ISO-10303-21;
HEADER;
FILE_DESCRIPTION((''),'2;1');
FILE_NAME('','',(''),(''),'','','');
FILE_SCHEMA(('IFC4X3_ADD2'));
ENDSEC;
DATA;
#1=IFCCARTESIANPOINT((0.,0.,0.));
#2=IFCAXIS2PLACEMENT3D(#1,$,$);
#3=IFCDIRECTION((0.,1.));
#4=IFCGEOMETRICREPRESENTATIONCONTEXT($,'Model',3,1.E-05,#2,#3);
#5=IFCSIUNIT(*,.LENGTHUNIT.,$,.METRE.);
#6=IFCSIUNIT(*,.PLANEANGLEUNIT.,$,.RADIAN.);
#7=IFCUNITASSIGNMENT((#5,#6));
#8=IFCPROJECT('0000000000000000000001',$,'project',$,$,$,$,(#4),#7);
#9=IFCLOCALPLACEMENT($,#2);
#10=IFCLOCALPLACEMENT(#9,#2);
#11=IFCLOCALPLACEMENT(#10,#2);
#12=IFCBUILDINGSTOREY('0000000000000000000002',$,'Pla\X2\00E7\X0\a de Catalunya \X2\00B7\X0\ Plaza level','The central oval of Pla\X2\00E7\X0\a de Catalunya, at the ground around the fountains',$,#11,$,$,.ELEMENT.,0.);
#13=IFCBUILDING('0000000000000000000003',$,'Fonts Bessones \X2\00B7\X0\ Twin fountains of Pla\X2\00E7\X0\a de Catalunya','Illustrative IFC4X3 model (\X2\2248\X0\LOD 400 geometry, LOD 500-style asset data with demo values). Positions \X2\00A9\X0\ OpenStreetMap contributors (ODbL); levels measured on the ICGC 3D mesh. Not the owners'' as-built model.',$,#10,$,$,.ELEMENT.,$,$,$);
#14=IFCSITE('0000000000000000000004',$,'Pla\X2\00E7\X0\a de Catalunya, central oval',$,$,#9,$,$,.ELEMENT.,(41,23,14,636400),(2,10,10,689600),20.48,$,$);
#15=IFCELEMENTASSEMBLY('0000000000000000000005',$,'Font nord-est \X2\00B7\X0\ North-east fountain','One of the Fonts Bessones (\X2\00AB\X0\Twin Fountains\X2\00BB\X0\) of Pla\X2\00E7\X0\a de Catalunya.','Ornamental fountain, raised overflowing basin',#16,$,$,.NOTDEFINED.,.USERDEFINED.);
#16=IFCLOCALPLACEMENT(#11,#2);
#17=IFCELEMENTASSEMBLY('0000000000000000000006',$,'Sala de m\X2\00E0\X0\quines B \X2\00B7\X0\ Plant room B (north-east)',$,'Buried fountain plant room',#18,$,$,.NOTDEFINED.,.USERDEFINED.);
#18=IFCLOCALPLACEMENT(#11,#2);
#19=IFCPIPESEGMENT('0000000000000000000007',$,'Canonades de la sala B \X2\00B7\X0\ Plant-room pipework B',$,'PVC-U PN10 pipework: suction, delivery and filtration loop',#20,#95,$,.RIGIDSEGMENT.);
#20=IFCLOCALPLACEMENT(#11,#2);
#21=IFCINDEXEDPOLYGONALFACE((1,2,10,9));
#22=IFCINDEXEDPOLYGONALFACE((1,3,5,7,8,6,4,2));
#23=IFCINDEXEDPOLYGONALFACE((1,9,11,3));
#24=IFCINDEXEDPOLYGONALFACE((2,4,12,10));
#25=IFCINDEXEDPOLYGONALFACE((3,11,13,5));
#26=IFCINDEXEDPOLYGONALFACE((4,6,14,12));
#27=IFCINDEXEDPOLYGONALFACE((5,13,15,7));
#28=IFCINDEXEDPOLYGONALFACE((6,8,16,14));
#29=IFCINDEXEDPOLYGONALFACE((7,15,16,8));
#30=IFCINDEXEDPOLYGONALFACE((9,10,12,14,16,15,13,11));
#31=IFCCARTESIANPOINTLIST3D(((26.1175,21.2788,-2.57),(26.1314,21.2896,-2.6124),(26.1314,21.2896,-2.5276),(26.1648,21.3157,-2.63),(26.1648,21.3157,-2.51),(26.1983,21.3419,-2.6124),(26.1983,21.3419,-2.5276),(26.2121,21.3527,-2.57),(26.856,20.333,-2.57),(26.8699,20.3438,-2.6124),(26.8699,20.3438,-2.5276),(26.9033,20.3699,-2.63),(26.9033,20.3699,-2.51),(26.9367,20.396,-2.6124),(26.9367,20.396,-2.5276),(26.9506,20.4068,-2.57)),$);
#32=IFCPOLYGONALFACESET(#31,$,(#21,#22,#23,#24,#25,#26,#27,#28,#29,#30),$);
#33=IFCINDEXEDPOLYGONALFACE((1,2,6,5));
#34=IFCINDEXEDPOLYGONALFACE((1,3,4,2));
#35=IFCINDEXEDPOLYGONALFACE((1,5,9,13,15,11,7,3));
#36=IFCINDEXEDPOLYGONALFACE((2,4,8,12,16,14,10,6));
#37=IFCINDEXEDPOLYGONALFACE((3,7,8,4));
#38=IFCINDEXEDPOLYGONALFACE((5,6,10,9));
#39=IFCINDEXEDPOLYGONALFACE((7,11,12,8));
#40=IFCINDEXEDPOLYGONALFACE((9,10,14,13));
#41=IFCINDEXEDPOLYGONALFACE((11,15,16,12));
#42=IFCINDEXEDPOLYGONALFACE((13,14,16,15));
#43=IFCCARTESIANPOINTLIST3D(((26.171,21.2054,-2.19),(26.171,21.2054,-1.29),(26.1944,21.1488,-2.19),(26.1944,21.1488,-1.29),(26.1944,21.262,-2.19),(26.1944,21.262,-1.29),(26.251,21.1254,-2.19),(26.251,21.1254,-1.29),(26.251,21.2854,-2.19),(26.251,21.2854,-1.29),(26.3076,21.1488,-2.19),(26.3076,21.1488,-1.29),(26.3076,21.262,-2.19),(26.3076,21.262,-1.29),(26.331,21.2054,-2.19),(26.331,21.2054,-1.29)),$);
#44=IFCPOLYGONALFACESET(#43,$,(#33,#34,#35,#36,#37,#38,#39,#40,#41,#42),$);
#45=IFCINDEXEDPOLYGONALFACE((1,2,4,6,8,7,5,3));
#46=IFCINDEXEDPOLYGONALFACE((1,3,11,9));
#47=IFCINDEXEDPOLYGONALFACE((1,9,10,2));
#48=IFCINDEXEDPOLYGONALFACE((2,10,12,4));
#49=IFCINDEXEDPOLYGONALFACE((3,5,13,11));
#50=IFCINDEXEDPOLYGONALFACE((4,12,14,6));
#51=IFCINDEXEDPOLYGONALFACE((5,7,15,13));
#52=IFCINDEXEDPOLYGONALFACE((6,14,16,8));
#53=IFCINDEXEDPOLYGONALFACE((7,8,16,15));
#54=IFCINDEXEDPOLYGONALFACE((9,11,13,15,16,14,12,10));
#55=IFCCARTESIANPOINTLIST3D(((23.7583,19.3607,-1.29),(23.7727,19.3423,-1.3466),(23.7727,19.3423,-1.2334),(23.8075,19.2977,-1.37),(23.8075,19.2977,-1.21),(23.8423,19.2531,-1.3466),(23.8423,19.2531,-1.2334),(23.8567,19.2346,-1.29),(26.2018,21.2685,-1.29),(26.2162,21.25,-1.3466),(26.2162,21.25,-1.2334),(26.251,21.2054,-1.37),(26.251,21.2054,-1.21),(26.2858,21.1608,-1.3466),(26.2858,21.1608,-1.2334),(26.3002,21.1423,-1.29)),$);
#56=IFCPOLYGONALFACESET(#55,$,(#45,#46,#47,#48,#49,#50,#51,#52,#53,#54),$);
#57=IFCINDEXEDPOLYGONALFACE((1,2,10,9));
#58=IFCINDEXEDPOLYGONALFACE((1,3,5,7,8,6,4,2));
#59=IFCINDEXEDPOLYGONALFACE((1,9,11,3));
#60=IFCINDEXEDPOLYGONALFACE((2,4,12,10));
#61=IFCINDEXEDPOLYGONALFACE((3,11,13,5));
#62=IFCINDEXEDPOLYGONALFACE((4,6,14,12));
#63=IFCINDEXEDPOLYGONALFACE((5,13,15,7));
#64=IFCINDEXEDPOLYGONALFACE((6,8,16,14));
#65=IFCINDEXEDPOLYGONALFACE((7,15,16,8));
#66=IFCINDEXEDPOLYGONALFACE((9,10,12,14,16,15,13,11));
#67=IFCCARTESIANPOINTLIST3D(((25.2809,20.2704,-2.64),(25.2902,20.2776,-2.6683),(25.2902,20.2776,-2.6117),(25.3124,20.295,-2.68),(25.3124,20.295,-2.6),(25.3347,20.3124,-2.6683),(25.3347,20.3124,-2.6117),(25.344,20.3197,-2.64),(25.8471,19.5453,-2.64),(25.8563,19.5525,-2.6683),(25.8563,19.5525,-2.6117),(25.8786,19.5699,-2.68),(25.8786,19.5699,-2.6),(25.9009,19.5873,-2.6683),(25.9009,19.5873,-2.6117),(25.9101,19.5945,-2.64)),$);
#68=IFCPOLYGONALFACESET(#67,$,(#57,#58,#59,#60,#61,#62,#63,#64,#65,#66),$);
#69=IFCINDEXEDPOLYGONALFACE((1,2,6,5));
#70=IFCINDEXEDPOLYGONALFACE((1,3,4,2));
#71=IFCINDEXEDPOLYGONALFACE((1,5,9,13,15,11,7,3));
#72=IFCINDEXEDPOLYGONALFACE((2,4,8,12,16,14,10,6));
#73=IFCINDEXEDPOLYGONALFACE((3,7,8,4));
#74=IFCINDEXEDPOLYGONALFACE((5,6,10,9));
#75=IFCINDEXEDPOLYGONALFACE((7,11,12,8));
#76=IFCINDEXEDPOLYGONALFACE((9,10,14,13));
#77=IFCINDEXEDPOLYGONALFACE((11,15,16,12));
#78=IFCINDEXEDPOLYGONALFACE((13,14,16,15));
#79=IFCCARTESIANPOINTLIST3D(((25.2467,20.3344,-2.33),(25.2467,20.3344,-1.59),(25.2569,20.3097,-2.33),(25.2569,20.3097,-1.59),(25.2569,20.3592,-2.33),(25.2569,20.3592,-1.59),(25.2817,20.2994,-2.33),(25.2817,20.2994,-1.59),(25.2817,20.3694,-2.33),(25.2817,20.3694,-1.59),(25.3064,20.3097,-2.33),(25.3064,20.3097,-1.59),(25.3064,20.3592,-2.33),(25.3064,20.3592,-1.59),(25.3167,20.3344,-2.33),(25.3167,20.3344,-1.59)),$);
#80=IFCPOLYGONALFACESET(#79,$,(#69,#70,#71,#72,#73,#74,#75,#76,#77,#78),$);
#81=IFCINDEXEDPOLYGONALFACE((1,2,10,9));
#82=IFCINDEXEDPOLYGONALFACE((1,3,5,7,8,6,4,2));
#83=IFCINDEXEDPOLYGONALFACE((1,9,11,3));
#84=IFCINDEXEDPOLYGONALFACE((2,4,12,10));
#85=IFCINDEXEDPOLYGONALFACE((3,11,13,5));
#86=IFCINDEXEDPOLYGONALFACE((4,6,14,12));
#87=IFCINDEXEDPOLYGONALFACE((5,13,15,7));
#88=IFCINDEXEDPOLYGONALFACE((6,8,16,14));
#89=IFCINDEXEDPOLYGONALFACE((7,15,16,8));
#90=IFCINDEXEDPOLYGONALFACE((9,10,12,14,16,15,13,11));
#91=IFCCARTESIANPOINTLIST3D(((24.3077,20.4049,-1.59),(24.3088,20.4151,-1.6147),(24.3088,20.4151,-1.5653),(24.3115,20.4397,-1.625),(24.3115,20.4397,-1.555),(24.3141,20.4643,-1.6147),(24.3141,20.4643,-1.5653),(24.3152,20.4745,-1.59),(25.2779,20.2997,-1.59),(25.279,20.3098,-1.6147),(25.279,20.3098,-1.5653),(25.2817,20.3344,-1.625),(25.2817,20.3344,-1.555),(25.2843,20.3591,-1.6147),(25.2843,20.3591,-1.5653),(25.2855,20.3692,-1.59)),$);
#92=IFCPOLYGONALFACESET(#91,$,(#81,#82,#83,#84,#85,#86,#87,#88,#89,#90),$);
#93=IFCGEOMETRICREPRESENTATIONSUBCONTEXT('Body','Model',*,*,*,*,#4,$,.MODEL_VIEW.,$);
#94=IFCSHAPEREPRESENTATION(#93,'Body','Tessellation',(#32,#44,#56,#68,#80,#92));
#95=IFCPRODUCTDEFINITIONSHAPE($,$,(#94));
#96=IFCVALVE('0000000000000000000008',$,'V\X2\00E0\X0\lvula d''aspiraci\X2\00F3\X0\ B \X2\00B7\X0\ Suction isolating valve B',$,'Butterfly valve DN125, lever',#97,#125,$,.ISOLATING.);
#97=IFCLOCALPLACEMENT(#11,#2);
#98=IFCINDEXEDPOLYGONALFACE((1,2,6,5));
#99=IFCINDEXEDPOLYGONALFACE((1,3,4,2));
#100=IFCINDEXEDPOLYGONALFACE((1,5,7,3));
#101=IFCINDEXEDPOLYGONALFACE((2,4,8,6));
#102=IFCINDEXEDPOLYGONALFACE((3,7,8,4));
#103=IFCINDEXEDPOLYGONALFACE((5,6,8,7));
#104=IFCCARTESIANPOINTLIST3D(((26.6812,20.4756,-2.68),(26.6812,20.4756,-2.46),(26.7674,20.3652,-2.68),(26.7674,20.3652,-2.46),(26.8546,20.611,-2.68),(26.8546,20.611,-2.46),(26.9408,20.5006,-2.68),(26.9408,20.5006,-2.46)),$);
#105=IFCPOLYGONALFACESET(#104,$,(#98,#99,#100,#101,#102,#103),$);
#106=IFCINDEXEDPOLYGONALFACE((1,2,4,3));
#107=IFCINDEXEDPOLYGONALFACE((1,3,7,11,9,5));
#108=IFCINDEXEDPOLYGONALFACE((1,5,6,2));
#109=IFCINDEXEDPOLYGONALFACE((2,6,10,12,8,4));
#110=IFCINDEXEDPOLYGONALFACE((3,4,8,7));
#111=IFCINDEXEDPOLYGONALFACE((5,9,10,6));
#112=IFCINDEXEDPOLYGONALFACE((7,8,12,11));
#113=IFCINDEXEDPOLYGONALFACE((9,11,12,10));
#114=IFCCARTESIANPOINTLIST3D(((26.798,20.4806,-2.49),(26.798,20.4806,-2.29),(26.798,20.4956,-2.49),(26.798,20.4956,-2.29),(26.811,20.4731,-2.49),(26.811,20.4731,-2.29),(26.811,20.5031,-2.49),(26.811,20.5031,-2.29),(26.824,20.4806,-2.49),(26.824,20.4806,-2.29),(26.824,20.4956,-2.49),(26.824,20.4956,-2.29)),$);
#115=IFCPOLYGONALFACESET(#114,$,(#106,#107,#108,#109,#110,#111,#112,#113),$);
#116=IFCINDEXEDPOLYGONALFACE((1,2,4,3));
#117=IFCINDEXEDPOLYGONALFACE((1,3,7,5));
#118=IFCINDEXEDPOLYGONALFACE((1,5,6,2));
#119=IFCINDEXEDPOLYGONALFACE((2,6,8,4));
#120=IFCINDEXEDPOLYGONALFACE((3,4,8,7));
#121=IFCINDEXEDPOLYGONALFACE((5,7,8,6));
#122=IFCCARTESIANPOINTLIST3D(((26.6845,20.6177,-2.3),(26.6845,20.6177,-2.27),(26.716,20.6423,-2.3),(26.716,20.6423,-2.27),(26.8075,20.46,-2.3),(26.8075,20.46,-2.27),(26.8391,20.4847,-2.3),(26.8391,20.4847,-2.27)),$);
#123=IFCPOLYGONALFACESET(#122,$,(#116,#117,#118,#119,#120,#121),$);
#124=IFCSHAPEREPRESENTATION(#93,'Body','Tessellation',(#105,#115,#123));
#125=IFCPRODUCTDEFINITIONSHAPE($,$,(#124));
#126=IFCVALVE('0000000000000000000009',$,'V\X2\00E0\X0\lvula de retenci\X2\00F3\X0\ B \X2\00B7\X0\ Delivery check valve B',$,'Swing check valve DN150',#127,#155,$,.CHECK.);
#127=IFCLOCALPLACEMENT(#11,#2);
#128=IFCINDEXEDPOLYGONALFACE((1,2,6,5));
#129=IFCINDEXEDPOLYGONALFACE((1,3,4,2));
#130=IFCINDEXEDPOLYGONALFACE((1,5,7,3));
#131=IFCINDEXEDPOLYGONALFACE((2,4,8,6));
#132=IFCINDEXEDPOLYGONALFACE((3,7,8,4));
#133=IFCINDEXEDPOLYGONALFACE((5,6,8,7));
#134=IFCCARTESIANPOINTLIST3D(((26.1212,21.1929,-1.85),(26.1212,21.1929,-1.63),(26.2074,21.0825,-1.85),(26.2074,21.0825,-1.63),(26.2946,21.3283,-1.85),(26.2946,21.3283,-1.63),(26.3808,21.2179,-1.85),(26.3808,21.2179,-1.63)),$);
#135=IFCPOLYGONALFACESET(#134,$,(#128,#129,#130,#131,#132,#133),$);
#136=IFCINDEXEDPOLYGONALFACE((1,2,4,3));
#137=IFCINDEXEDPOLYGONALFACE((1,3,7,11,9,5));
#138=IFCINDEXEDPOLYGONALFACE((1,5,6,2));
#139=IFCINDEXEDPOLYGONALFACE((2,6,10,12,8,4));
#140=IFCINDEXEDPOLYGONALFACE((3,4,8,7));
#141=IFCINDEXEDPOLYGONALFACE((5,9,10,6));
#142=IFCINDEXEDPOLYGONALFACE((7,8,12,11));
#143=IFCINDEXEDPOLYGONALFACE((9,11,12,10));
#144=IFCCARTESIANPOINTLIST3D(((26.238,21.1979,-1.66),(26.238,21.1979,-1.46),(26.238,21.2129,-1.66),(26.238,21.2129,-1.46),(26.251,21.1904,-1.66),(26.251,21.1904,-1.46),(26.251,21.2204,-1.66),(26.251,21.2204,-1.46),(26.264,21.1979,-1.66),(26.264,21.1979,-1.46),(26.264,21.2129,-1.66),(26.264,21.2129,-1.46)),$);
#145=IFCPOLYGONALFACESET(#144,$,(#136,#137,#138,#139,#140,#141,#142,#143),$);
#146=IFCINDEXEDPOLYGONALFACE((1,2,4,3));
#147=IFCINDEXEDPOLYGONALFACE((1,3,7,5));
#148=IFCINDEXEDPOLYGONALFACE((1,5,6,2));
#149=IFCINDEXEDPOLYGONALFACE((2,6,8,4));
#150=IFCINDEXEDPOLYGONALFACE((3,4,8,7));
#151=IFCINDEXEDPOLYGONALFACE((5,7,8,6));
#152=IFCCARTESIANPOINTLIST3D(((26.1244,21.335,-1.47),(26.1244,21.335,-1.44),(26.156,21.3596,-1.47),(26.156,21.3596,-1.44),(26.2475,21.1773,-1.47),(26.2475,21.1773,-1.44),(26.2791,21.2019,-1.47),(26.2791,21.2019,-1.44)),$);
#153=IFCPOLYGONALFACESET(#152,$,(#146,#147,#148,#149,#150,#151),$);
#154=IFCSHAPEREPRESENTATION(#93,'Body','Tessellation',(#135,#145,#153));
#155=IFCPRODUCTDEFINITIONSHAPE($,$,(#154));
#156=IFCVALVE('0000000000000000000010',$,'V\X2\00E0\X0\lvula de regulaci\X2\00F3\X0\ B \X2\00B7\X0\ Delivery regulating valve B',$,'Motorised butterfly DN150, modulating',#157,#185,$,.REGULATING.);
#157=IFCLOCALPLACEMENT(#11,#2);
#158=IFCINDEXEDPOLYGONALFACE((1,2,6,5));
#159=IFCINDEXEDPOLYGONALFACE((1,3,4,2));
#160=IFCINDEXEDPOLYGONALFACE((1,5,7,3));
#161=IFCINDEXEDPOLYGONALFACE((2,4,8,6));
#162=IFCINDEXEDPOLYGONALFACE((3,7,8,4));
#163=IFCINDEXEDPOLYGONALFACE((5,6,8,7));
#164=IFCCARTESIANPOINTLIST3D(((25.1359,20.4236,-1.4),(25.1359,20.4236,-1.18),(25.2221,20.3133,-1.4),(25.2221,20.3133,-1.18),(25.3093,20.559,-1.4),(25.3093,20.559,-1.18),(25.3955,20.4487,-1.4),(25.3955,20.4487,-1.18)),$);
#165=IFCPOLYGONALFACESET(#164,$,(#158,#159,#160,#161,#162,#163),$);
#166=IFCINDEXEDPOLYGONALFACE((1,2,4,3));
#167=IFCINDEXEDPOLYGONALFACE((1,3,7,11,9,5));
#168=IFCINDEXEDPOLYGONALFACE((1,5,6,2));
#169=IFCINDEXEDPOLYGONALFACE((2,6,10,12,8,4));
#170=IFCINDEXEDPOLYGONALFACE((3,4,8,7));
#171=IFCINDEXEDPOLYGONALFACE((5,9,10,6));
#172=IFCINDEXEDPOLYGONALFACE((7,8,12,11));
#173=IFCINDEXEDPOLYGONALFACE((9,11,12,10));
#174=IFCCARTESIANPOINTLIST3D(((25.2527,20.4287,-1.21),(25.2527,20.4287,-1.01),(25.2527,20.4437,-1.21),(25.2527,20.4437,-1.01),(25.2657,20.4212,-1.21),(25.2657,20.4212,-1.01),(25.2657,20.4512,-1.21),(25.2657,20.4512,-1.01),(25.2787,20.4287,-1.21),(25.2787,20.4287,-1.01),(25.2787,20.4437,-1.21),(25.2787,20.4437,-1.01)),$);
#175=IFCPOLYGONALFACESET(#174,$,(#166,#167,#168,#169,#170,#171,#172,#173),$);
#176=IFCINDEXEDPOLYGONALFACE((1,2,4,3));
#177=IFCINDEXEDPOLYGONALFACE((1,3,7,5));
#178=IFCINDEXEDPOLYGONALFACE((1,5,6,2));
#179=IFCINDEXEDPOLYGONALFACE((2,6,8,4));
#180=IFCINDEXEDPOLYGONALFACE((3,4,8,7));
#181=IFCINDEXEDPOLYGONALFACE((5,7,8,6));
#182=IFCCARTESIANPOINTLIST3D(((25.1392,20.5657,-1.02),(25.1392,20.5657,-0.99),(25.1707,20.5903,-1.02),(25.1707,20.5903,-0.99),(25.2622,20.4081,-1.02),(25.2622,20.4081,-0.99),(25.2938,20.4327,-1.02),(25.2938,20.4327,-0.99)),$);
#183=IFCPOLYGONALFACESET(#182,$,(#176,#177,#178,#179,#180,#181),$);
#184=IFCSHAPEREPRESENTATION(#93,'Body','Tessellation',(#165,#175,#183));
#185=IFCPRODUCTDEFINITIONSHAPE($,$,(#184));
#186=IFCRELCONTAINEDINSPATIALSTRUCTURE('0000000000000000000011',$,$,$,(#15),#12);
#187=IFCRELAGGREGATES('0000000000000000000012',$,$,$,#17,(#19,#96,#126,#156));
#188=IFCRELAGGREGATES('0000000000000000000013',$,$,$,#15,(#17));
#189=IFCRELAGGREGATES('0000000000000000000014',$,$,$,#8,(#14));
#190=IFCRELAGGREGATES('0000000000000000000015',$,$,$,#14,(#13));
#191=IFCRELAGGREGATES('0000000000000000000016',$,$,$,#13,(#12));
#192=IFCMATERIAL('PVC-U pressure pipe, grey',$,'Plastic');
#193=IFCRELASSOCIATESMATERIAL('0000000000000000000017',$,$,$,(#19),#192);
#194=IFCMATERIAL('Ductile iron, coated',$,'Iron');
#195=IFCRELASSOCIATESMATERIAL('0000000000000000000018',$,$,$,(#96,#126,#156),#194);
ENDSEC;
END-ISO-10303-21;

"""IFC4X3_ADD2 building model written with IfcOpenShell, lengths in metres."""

from ifc_helpers import new_model, si_unit, direction, frame, frame_2d, origin, place, context, subcontext, project, spatial, polyline, rectangle, outline, extrude, material, element, aggregate, save


model = new_model("IFC4X3_ADD2")

# Units and contexts
model_context = context("Model", 3, precision=1e-05, world=origin(), true_north=direction((0.0, 1.0)))
body_context = subcontext(model_context, "Body", "Model", "MODEL_VIEW")
ifc_project = project(units=[si_unit("LENGTHUNIT", "METRE"), si_unit("PLANEANGLEUNIT", "RADIAN")], contexts=[model_context])

# Site, building, storey
site_placement = place(None, origin())
site = spatial("IfcSite", under=ifc_project, at=site_placement, Name="Plaça de Catalunya, central oval", CompositionType="ELEMENT", RefLatitude=(41, 23, 14, 636400), RefLongitude=(2, 10, 10, 689600), RefElevation=20.48)
building_placement = place(site_placement, origin())
building = spatial("IfcBuilding", under=site, at=building_placement, Name="Fonts Bessones · Twin fountains of Plaça de Catalunya", Description="Illustrative IFC4X3 model (≈LOD 400 geometry, LOD 500-style asset data with demo values). Positions © OpenStreetMap contributors (ODbL); levels measured on the ICGC 3D mesh. Not the owners' as-built model.", CompositionType="ELEMENT")
storey_placement = place(building_placement, origin())
storey = spatial("IfcBuildingStorey", under=building, at=storey_placement, Name="Plaça de Catalunya · Plaza level", Description="The central oval of Plaça de Catalunya, at the ground around the fountains", CompositionType="ELEMENT", Elevation=0.0)

# Element assemblies
assembly_1_placement = place(building_placement, origin())
assembly_1 = element("IfcElementAssembly", 1, at=assembly_1_placement, inside=storey, Name="Font nord-est · North-east fountain", Description="One of the Fonts Bessones («Twin Fountains») of Plaça de Catalunya.", ObjectType="Ornamental fountain, raised overflowing basin", AssemblyPlace="NOTDEFINED", PredefinedType="USERDEFINED")
assembly_2_placement = place(building_placement, origin())
assembly_2 = element("IfcElementAssembly", 2, at=assembly_2_placement, Name="Sala de màquines B · Plant room B (north-east)", ObjectType="Buried fountain plant room", AssemblyPlace="NOTDEFINED", PredefinedType="USERDEFINED")

# Pipe segment
ifc_material_1 = material(Name="PVC-U pressure pipe, grey", Category="Plastic")
pipe_segment_1_placement = place(building_placement, origin())
pipe_segment_1 = element("IfcPipeSegment", 3, at=pipe_segment_1_placement, material=ifc_material_1, Name="Canonades de la sala B · Plant-room pipework B", ObjectType="PVC-U PN10 pipework: suction, delivery and filtration loop", PredefinedType="RIGIDSEGMENT", context=body_context, shape_type="SweptSolid", body=[
    extrude(outline(polyline([(0.06, 0.0), (0.0424, 0.0424), (0.0, 0.06), (-0.0424, 0.0424), (-0.06, 0.0), (-0.0424, -0.0424), (0.0, -0.06), (0.0424, -0.0424), (0.06, 0.0)])), frame((26.9033, 20.3699, -2.57), z_axis=(-0.61539, 0.788223, 0.0), x_axis=(0.788223, 0.61539, 0.0)), (0.0, 0.0, 1.0), 1.2),
    extrude(outline(polyline([(0.08, 0.0), (0.0566, 0.0566), (0.0, 0.08), (-0.0566, 0.0566), (-0.08, 0.0), (-0.0566, -0.0566), (0.0, -0.08), (0.0566, -0.0566), (0.08, 0.0)])), frame((26.251, 21.2054, -2.19), z_axis=(0.0, 0.0, 1.0), x_axis=(0.0, 1.0, 0.0)), (0.0, 0.0, 1.0), 0.9),
    extrude(outline(polyline([(0.08, 0.0), (0.0566, 0.0566), (0.0, 0.08), (-0.0566, 0.0566), (-0.08, 0.0), (-0.0566, -0.0566), (0.0, -0.08), (0.0566, -0.0566), (0.08, 0.0)])), frame((26.251, 21.2054, -1.29), z_axis=(-0.788223, -0.61539, 0.0), x_axis=(-0.61539, 0.788223, 0.0)), (0.0, 0.0, 1.0), 3.1),
    extrude(outline(polyline([(0.04, 0.0), (0.0283, 0.0283), (0.0, 0.04), (-0.0283, 0.0283), (-0.04, 0.0), (-0.0283, -0.0283), (0.0, -0.04), (0.0283, -0.0283), (0.04, 0.0)])), frame((25.8786, 19.5699, -2.64), z_axis=(-0.61539, 0.788223, 0.0), x_axis=(0.788223, 0.61539, 0.0)), (0.0, 0.0, 1.0), 0.92),
    extrude(outline(polyline([(0.035, 0.0), (0.0247, 0.0247), (0.0, 0.035), (-0.0247, 0.0247), (-0.035, 0.0), (-0.0247, -0.0247), (0.0, -0.035), (0.0247, -0.0247), (0.035, 0.0)])), frame((25.2817, 20.3344, -2.33), z_axis=(0.0, 0.0, 1.0), x_axis=(0.0, 1.0, 0.0)), (0.0, 0.0, 1.0), 0.74),
    extrude(outline(polyline([(0.035, 0.0), (0.0247, 0.0247), (0.0, 0.035), (-0.0247, 0.0247), (-0.035, 0.0), (-0.0247, -0.0247), (0.0, -0.035), (0.0247, -0.0247), (0.035, 0.0)])), frame((25.2817, 20.3344, -1.59), z_axis=(-0.994171, 0.107816, 0.0), x_axis=(0.107816, 0.994171, 0.0)), (0.0, 0.0, 1.0), 0.9759),
])

# Valves
ifc_material_2 = material(Name="Ductile iron, coated", Category="Iron")
valve_1_placement = place(building_placement, origin())
valve_1 = element("IfcValve", 4, at=valve_1_placement, material=ifc_material_2, Name="Vàlvula d'aspiració B · Suction isolating valve B", ObjectType="Butterfly valve DN125, lever", PredefinedType="ISOLATING", context=body_context, shape_type="SweptSolid", body=[
    extrude(rectangle(XDim=0.14, YDim=0.22, at=frame_2d((0.0, 0.0), x_axis=(-0.61539, 0.788223))), frame((26.811, 20.4881, -2.68)), (0.0, 0.0, 1.0), 0.22),
    extrude(outline(polyline([(0.015, 0.0), (0.0075, 0.013), (-0.0075, 0.013), (-0.015, 0.0), (-0.0075, -0.013), (0.0075, -0.013), (0.015, 0.0)])), frame((26.811, 20.4881, -2.49), z_axis=(0.0, 0.0, 1.0), x_axis=(0.0, 1.0, 0.0)), (0.0, 0.0, 1.0), 0.2),
    extrude(rectangle(XDim=0.2, YDim=0.04, at=frame_2d((0.0, 0.0), x_axis=(-0.61539, 0.788223))), frame((26.7618, 20.5512, -2.3)), (0.0, 0.0, 1.0), 0.03),
])
valve_2_placement = place(building_placement, origin())
valve_2 = element("IfcValve", 5, at=valve_2_placement, material=ifc_material_2, Name="Vàlvula de retenció B · Delivery check valve B", ObjectType="Swing check valve DN150", PredefinedType="CHECK", context=body_context, shape_type="SweptSolid", body=[
    extrude(rectangle(XDim=0.14, YDim=0.22, at=frame_2d((0.0, 0.0), x_axis=(-0.61539, 0.788223))), frame((26.251, 21.2054, -1.85)), (0.0, 0.0, 1.0), 0.22),
    extrude(outline(polyline([(0.015, 0.0), (0.0075, 0.013), (-0.0075, 0.013), (-0.015, 0.0), (-0.0075, -0.013), (0.0075, -0.013), (0.015, 0.0)])), frame((26.251, 21.2054, -1.66), z_axis=(0.0, 0.0, 1.0), x_axis=(0.0, 1.0, 0.0)), (0.0, 0.0, 1.0), 0.2),
    extrude(rectangle(XDim=0.2, YDim=0.04, at=frame_2d((0.0, 0.0), x_axis=(-0.61539, 0.788223))), frame((26.2018, 21.2685, -1.47)), (0.0, 0.0, 1.0), 0.03),
])
valve_3_placement = place(building_placement, origin())
valve_3 = element("IfcValve", 6, at=valve_3_placement, material=ifc_material_2, Name="Vàlvula de regulació B · Delivery regulating valve B", ObjectType="Motorised butterfly DN150, modulating", PredefinedType="REGULATING", context=body_context, shape_type="SweptSolid", body=[
    extrude(rectangle(XDim=0.14, YDim=0.22, at=frame_2d((0.0, 0.0), x_axis=(-0.61539, 0.788223))), frame((25.2657, 20.4362, -1.4)), (0.0, 0.0, 1.0), 0.22),
    extrude(outline(polyline([(0.015, 0.0), (0.0075, 0.013), (-0.0075, 0.013), (-0.015, 0.0), (-0.0075, -0.013), (0.0075, -0.013), (0.015, 0.0)])), frame((25.2657, 20.4362, -1.21), z_axis=(0.0, 0.0, 1.0), x_axis=(0.0, 1.0, 0.0)), (0.0, 0.0, 1.0), 0.2),
    extrude(rectangle(XDim=0.2, YDim=0.04, at=frame_2d((0.0, 0.0), x_axis=(-0.61539, 0.788223))), frame((25.2165, 20.4992, -1.02)), (0.0, 0.0, 1.0), 0.03),
])

aggregate(assembly_2, [pipe_segment_1, valve_1, valve_2, valve_3])

aggregate(assembly_1, [assembly_2])

save(model, "model.ifc")
